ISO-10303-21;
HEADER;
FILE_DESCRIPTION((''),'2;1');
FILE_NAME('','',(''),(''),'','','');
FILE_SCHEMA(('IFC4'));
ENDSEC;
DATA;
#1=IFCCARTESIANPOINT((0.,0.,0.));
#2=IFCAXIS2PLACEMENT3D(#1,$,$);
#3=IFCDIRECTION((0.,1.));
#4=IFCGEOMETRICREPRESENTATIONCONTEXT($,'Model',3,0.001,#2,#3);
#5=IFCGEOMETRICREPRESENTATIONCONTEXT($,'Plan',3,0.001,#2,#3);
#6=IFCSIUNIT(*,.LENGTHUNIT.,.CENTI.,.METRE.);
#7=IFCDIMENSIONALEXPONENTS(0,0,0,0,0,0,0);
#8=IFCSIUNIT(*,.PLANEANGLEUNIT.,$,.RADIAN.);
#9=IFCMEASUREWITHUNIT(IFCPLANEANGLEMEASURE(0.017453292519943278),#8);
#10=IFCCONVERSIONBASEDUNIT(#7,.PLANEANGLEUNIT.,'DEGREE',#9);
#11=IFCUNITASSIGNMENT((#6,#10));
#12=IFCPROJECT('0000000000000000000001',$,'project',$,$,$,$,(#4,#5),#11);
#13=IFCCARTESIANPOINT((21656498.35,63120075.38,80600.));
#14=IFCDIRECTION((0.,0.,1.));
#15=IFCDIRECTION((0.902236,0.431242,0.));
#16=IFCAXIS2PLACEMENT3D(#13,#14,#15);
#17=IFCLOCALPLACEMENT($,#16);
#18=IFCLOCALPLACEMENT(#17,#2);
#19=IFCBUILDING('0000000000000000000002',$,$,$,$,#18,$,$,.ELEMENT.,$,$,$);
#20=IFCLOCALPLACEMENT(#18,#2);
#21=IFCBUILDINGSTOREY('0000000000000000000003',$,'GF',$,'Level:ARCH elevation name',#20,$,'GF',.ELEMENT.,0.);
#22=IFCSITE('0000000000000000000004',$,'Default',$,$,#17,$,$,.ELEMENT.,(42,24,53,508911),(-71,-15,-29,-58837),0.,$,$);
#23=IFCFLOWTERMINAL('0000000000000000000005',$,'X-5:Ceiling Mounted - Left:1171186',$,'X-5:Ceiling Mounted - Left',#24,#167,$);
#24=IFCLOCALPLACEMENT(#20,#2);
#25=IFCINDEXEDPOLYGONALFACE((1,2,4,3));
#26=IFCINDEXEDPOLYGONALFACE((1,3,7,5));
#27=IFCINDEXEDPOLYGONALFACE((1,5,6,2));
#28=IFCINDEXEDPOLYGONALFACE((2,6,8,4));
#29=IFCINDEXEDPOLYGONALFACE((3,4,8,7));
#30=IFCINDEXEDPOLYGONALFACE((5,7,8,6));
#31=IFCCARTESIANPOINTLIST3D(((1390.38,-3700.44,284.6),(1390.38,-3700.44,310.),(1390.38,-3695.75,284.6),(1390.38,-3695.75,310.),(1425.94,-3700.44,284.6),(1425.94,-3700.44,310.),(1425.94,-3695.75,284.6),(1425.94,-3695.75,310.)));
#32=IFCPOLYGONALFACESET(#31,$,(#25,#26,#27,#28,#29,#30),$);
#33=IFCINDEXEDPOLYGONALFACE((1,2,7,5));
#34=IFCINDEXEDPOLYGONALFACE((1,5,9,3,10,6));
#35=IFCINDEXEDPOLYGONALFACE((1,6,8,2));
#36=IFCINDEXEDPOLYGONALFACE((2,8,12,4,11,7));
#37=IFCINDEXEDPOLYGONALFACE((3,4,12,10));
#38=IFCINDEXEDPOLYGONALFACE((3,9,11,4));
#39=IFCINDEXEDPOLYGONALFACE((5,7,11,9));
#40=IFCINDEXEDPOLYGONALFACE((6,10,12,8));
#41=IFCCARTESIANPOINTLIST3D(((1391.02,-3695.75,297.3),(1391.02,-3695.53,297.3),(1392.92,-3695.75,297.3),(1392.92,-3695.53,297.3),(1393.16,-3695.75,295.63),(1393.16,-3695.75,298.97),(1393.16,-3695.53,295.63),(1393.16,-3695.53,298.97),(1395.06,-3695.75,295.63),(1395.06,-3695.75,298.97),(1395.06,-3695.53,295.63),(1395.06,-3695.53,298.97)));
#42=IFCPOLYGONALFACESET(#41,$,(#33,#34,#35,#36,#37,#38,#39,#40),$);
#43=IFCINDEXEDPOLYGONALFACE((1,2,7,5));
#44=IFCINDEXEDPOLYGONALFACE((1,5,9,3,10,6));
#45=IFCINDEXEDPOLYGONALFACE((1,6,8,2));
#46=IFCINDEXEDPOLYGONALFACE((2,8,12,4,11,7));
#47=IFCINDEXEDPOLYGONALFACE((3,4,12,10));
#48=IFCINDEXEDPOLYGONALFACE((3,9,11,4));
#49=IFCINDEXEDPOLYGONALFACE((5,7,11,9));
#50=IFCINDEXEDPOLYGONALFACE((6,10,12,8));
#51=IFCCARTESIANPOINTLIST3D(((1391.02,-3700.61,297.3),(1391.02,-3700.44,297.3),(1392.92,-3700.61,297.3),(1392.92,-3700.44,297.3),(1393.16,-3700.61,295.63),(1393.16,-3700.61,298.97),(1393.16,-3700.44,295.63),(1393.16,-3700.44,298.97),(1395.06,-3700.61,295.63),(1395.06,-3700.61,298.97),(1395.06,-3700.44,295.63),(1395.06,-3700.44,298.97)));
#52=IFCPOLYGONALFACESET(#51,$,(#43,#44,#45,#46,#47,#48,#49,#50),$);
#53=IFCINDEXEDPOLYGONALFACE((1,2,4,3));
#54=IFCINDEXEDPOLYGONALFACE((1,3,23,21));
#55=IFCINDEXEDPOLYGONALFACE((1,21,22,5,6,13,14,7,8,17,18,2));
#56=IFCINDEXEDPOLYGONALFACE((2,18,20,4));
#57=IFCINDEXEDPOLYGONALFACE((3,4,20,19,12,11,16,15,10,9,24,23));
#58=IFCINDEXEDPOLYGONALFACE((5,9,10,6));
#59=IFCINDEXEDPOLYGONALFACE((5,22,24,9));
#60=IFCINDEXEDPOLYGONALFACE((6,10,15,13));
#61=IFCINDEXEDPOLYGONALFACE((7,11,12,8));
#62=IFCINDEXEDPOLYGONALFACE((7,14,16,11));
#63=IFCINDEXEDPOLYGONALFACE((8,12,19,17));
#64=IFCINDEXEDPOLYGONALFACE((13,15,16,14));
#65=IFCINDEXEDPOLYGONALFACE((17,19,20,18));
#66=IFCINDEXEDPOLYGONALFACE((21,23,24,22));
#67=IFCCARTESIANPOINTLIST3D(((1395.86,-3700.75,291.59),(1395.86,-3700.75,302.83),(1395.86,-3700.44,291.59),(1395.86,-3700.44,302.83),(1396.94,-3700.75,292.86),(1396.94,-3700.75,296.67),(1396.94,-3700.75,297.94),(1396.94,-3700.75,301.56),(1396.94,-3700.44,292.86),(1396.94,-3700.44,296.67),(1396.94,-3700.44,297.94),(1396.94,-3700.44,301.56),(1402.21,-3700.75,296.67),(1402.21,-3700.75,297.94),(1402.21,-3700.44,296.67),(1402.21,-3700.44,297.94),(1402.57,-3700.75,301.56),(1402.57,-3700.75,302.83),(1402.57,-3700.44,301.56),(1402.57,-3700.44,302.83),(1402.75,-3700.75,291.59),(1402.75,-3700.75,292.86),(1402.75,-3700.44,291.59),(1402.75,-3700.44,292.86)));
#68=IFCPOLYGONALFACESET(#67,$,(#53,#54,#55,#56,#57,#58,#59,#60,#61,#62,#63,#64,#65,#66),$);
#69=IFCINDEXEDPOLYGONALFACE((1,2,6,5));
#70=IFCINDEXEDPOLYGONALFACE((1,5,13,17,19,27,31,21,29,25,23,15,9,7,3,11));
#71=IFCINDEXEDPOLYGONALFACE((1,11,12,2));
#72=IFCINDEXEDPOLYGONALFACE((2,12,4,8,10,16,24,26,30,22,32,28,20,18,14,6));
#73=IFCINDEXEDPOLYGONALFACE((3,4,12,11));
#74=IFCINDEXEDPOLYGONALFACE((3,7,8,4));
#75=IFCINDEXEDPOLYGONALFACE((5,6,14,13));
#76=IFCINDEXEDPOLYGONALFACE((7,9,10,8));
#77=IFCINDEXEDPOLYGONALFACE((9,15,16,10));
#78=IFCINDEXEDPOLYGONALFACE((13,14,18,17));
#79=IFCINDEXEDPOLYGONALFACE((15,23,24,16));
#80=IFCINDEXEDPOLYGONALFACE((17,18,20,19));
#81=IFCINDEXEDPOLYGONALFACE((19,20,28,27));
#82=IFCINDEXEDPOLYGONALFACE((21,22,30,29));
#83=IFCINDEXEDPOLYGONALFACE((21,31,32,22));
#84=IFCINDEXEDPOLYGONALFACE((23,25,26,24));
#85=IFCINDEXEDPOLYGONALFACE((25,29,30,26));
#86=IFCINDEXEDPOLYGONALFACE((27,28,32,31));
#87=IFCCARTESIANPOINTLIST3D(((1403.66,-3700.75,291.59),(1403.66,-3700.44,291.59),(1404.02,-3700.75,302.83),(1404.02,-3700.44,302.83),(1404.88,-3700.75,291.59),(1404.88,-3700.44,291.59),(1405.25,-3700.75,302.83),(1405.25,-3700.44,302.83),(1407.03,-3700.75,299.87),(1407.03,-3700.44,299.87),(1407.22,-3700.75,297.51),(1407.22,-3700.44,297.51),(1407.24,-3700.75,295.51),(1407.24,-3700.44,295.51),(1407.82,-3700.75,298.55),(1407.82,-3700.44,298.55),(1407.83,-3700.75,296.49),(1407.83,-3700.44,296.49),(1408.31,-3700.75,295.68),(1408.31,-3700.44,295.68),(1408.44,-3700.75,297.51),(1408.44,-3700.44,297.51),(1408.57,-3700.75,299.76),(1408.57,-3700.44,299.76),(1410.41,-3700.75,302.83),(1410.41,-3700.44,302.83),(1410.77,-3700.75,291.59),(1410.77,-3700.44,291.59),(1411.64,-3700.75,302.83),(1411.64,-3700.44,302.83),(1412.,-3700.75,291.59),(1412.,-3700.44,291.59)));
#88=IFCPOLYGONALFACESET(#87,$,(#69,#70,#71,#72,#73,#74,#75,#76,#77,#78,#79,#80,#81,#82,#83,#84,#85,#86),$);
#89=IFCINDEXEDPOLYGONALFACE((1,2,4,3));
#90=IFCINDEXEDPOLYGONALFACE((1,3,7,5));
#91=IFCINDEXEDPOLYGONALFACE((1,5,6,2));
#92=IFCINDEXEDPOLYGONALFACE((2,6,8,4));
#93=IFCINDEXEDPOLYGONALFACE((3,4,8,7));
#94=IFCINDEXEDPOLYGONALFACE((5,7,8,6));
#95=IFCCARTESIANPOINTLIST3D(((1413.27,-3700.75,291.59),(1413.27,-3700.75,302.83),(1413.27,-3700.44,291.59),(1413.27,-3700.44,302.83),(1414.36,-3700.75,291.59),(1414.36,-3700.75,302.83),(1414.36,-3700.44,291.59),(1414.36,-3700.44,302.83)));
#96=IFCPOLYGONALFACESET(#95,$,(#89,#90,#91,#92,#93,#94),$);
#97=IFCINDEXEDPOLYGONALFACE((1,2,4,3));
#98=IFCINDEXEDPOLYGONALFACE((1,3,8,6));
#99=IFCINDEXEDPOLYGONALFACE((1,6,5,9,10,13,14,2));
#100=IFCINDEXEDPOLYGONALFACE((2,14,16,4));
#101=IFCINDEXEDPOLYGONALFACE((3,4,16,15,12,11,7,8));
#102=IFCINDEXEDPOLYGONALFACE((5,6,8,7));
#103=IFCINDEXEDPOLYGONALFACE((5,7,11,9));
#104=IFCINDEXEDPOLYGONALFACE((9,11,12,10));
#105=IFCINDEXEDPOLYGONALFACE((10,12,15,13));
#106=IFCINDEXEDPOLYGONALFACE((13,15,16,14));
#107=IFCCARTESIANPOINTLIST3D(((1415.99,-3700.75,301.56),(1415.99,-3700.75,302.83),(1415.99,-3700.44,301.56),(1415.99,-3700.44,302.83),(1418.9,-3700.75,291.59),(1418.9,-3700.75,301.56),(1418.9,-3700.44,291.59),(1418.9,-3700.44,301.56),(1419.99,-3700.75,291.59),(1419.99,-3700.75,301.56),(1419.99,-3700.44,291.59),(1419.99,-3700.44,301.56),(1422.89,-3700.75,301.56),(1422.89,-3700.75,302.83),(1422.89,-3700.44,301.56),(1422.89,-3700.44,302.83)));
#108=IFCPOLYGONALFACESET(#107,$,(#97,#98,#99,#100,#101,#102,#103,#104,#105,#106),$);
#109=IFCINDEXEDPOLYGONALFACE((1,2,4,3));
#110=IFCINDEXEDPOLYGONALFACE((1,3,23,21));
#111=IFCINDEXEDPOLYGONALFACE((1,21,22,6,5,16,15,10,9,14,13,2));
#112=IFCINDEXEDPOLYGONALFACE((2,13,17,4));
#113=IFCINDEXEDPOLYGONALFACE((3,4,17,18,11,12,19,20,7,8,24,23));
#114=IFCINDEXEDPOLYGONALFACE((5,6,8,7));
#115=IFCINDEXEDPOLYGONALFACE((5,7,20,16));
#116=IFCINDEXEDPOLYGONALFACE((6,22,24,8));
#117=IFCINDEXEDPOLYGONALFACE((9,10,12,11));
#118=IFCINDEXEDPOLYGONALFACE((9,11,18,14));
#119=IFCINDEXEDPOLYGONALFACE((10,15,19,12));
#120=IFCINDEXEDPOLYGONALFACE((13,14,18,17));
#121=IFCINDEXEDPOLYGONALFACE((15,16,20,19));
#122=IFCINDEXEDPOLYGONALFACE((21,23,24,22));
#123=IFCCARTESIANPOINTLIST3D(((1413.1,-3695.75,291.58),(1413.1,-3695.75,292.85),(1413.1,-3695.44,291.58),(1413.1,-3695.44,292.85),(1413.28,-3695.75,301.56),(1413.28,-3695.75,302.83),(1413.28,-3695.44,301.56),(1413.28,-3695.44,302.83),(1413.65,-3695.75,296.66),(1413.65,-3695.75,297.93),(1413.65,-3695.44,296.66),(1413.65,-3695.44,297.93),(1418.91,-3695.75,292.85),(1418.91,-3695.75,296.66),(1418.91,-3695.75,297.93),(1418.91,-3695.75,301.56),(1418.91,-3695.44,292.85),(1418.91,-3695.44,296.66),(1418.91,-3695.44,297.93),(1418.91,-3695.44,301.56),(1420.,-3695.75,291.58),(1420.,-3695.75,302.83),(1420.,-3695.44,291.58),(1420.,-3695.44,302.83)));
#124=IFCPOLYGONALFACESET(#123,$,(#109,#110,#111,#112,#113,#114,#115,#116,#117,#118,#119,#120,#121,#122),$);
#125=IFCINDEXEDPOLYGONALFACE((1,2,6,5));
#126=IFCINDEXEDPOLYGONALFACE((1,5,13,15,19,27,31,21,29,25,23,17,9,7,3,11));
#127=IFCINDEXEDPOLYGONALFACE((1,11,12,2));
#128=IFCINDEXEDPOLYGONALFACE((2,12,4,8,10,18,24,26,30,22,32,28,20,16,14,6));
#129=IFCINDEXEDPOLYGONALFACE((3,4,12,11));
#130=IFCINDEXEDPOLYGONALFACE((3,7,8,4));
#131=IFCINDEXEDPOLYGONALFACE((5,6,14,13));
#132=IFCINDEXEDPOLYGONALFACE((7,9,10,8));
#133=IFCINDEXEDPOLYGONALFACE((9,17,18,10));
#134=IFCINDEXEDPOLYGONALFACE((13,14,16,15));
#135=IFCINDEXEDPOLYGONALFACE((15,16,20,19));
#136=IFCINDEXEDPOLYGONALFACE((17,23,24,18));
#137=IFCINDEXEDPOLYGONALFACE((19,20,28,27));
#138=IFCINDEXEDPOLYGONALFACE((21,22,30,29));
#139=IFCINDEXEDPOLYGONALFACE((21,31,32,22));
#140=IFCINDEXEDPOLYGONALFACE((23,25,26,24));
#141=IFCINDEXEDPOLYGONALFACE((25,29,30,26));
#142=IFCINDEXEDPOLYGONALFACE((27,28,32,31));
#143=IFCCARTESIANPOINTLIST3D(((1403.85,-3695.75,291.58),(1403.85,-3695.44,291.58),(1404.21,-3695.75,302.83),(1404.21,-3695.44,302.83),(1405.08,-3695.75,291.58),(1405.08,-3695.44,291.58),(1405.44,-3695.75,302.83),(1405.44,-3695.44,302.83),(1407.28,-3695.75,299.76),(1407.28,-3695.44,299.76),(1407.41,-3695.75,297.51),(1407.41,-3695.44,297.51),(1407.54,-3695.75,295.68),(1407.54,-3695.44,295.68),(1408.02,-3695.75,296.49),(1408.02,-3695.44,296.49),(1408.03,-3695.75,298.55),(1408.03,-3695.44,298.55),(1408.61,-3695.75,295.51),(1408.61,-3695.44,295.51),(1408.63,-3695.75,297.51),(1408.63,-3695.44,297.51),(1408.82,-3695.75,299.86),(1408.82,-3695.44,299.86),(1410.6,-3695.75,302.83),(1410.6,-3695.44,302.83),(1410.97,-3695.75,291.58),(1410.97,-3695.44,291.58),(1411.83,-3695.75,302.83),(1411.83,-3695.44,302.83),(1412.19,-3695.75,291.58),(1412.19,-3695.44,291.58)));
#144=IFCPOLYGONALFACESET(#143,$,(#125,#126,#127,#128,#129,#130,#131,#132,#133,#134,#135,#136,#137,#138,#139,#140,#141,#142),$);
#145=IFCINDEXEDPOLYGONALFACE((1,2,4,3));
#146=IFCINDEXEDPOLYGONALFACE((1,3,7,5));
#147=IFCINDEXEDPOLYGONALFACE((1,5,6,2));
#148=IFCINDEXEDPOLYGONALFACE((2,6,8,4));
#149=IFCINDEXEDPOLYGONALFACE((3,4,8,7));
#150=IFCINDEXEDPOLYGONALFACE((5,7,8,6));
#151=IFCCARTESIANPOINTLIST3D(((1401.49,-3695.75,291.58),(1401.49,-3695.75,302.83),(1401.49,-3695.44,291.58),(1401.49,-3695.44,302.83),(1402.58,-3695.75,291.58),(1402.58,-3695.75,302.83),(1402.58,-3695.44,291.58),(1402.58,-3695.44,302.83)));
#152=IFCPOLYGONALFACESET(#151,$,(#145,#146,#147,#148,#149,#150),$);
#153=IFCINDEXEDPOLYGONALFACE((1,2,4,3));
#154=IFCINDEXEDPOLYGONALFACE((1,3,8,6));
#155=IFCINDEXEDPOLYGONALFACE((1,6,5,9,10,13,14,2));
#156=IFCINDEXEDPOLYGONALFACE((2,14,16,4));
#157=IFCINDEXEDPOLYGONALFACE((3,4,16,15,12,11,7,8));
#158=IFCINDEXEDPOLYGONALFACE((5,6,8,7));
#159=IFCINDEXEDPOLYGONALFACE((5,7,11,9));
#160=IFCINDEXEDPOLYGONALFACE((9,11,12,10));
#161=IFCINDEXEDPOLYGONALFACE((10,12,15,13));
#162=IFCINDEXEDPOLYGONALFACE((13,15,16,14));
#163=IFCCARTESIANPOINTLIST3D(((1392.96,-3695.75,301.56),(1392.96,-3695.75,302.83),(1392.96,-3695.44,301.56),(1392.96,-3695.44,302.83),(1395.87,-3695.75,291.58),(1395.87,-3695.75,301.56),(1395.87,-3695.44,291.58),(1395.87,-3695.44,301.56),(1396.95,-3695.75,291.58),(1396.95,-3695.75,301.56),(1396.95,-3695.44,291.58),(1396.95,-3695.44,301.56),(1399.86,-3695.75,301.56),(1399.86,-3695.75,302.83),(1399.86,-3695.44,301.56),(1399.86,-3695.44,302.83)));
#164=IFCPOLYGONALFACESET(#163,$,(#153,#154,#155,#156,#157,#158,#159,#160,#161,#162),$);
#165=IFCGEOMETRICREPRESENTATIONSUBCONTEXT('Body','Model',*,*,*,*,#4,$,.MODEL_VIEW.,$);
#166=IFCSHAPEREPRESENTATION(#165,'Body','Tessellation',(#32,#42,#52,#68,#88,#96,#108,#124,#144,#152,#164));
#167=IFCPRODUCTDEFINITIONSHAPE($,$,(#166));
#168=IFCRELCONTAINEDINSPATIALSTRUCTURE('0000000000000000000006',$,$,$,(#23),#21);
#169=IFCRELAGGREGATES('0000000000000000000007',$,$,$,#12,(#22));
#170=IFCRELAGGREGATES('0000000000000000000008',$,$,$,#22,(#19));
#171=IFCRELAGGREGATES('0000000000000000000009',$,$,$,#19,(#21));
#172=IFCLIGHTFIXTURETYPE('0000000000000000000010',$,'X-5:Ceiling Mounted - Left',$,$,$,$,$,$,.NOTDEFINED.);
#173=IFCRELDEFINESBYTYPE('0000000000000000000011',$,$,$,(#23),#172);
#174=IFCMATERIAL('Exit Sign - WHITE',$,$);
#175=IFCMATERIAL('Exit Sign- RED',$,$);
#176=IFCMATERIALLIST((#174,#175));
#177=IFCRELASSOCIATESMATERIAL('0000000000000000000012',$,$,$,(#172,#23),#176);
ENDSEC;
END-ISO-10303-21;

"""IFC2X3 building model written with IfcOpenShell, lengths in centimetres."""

from ifc_helpers import new_model, entity, si_unit, converted_unit, direction, frame, frame_2d, origin, place, context, subcontext, project, spatial, polyline, rectangle, outline, extrude, source, transform, mapped, material, material_list, type_object, type_shapes, element, save


model = new_model("IFC2X3")

# Units and contexts
model_context = context("Model", 3, precision=0.001, world=origin(), true_north=direction((0.0, 1.0)))
plan_context = context("Plan", 3, precision=0.001, world=origin(), true_north=direction((0.0, 1.0)))
body_context = subcontext(model_context, "Body", "Model", "MODEL_VIEW")
ifc_project = project(units=[si_unit("LENGTHUNIT", "METRE", prefix="CENTI"), converted_unit("PLANEANGLEUNIT", "DEGREE", entity("IfcPlaneAngleMeasure", 0.017453292519943278), si_unit("PLANEANGLEUNIT", "RADIAN"), dimensions=[0, 0, 0, 0, 0, 0, 0])], contexts=[model_context, plan_context])

# Site, building, storey
site_placement = place(None, frame((21656498.35, 63120075.38, 80600.0), z_axis=(0.0, 0.0, 1.0), x_axis=(0.902236, 0.431242, 0.0)))
site = spatial("IfcSite", under=ifc_project, at=site_placement, Name="Default", CompositionType="ELEMENT", RefLatitude=(42, 24, 53, 508911), RefLongitude=(-71, -15, -29, -58837), RefElevation=0.0)
building_placement = place(site_placement, origin())
building = spatial("IfcBuilding", under=site, at=building_placement, CompositionType="ELEMENT")
storey_placement = place(building_placement, origin())
storey = spatial("IfcBuildingStorey", under=building, at=storey_placement, Name="GF", ObjectType="Level:ARCH elevation name", LongName="GF", CompositionType="ELEMENT", Elevation=0.0)

# Flow terminal
ifc_material_1 = material(Name="Exit Sign - WHITE")
ifc_material_2 = material(Name="Exit Sign- RED")
ifc_material_list_1 = material_list([ifc_material_1, ifc_material_2])
light_fixture_type_1 = type_object("IfcLightFixtureType", Name="X-5:Ceiling Mounted - Left", PredefinedType="NOTDEFINED", material=ifc_material_list_1)
shared_shape_1 = source(origin(), body_context, "Body", "SweptSolid", [
    extrude(rectangle(XDim=4.68, YDim=35.56, at=frame_2d((0.0, 0.0), x_axis=(1.0, 0.0))), frame((0.0, 1.02, -25.4), z_axis=(0.0, 0.0, 1.0), x_axis=(0.0, 1.0, 0.0)), (0.0, 0.0, 1.0), 25.4),
    extrude(outline(polyline([(-0.24, -1.67), (1.67, -1.67), (-0.47, 0.0), (1.67, 1.67), (-0.24, 1.67), (-2.38, 0.0), (-0.24, -1.67)])), frame((-14.77, 3.36, -12.7), z_axis=(0.0, 1.0, 0.0), x_axis=(1.0, 0.0, 0.0)), (0.0, 0.0, 1.0), 0.22),
    extrude(outline(polyline([(-0.24, -1.67), (1.67, -1.67), (-0.47, 0.0), (1.67, 1.67), (-0.24, 1.67), (-2.38, 0.0), (-0.24, -1.67)])), frame((-14.77, -1.49, -12.7), z_axis=(0.0, 1.0, 0.0), x_axis=(1.0, 0.0, 0.0)), (0.0, 0.0, 1.0), 0.18),
    extrude(outline(polyline([(-5.65, -3.69), (5.59, -3.69), (5.59, 3.02), (4.32, 3.02), (4.32, -2.6), (0.7, -2.6), (0.7, 2.66), (-0.57, 2.66), (-0.57, -2.6), (-4.38, -2.6), (-4.38, 3.21), (-5.65, 3.21), (-5.65, -3.69)])), frame((-8.62, -1.63, -12.76), z_axis=(0.0, 1.0, 0.0), x_axis=(0.0, 0.0, 1.0)), (0.0, 0.0, 1.0), 0.32),
    extrude(outline(polyline([(-7.14, 0.57), (-6.5, -0.49), (-1.93, -0.48), (-0.78, -0.48), (-1.23, -1.32), (-3.47, -5.53), (-2.84, -6.59), (0.41, -0.48), (6.62, -0.48), (5.99, 0.57), (2.4, 0.57), (0.98, 0.58), (1.7, 1.94), (3.32, 5.0), (2.69, 6.05), (-0.22, 0.57), (-7.14, 0.57)])), frame((-0.34, -1.63, -12.59), z_axis=(0.0, -1.0, 0.0), x_axis=(0.515099, 0.0, 0.857131)), (0.0, 0.0, -1.0), 0.32),
    extrude(rectangle(XDim=0.32, YDim=1.09, at=frame_2d((0.0, 0.0), x_axis=(1.0, 0.0))), frame((5.65, -1.48, -18.41), z_axis=(0.0, 0.0, 1.0), x_axis=(0.0, 1.0, 0.0)), (0.0, 0.0, 1.0), 11.25),
    extrude(outline(polyline([(-7.8, 0.54), (-7.8, -0.54), (2.18, -0.54), (2.18, -3.45), (3.45, -3.45), (3.45, 3.45), (2.18, 3.45), (2.18, 0.54), (-7.8, 0.54)])), frame((11.28, -1.63, -10.61), z_axis=(0.0, -1.0, 0.0), x_axis=(0.0, 0.0, 1.0)), (0.0, 0.0, -1.0), 0.32),
    extrude(outline(polyline([(-3.69, -5.65), (3.21, -5.65), (3.21, -4.38), (-2.6, -4.38), (-2.6, -0.57), (2.66, -0.57), (2.66, 0.7), (-2.6, 0.7), (-2.6, 4.32), (3.02, 4.32), (3.02, 5.59), (-3.69, 5.59), (-3.69, -5.65)])), frame((8.14, 3.36, -12.76), z_axis=(0.0, 1.0, 0.0), x_axis=(-1.0, 0.0, 0.0)), (0.0, 0.0, 1.0), 0.32),
    extrude(outline(polyline([(-4.16, -5.82), (-2.93, -5.82), (-0.58, -1.9), (0.01, -0.92), (0.5, -1.73), (2.96, -5.82), (4.18, -5.82), (0.62, 0.1), (3.82, 5.42), (2.59, 5.42), (0.75, 2.35), (0.01, 1.14), (-0.79, 2.46), (-2.57, 5.42), (-3.8, 5.42), (-0.6, 0.1), (-4.16, -5.82)])), frame((-0.13, 3.36, -12.59), z_axis=(0.0, 1.0, 0.0), x_axis=(-1.0, 0.0, 0.0)), (0.0, 0.0, 1.0), 0.32),
    extrude(rectangle(XDim=0.32, YDim=1.09, at=frame_2d((0.0, 0.0), x_axis=(1.0, 0.0))), frame((-6.13, 3.52, -18.42), z_axis=(0.0, 0.0, 1.0), x_axis=(0.0, -1.0, 0.0)), (0.0, 0.0, 1.0), 11.25),
    extrude(outline(polyline([(-0.54, -7.8), (0.54, -7.8), (0.54, 2.18), (3.45, 2.18), (3.45, 3.45), (-3.45, 3.45), (-3.45, 2.18), (-0.54, 2.18), (-0.54, -7.8)])), frame((-11.75, 3.36, -10.62), z_axis=(0.0, 1.0, 0.0), x_axis=(-1.0, 0.0, 0.0)), (0.0, 0.0, 1.0), 0.32),
])
type_shapes(light_fixture_type_1, [shared_shape_1])
flow_terminal_1_placement = place(storey_placement, frame((1408.16, -3699.12, 310.0)))
element("IfcFlowTerminal", 1, at=flow_terminal_1_placement, inside=storey, type_object=light_fixture_type_1, material=ifc_material_list_1, Name="X-5:Ceiling Mounted - Left:1171186", ObjectType="X-5:Ceiling Mounted - Left", context=body_context, shape_type="MappedRepresentation", body=[
    mapped(shared_shape_1, transform((0.0, 0.0, 0.0), scale=1.0)),
])

save(model, "model.ifc")
